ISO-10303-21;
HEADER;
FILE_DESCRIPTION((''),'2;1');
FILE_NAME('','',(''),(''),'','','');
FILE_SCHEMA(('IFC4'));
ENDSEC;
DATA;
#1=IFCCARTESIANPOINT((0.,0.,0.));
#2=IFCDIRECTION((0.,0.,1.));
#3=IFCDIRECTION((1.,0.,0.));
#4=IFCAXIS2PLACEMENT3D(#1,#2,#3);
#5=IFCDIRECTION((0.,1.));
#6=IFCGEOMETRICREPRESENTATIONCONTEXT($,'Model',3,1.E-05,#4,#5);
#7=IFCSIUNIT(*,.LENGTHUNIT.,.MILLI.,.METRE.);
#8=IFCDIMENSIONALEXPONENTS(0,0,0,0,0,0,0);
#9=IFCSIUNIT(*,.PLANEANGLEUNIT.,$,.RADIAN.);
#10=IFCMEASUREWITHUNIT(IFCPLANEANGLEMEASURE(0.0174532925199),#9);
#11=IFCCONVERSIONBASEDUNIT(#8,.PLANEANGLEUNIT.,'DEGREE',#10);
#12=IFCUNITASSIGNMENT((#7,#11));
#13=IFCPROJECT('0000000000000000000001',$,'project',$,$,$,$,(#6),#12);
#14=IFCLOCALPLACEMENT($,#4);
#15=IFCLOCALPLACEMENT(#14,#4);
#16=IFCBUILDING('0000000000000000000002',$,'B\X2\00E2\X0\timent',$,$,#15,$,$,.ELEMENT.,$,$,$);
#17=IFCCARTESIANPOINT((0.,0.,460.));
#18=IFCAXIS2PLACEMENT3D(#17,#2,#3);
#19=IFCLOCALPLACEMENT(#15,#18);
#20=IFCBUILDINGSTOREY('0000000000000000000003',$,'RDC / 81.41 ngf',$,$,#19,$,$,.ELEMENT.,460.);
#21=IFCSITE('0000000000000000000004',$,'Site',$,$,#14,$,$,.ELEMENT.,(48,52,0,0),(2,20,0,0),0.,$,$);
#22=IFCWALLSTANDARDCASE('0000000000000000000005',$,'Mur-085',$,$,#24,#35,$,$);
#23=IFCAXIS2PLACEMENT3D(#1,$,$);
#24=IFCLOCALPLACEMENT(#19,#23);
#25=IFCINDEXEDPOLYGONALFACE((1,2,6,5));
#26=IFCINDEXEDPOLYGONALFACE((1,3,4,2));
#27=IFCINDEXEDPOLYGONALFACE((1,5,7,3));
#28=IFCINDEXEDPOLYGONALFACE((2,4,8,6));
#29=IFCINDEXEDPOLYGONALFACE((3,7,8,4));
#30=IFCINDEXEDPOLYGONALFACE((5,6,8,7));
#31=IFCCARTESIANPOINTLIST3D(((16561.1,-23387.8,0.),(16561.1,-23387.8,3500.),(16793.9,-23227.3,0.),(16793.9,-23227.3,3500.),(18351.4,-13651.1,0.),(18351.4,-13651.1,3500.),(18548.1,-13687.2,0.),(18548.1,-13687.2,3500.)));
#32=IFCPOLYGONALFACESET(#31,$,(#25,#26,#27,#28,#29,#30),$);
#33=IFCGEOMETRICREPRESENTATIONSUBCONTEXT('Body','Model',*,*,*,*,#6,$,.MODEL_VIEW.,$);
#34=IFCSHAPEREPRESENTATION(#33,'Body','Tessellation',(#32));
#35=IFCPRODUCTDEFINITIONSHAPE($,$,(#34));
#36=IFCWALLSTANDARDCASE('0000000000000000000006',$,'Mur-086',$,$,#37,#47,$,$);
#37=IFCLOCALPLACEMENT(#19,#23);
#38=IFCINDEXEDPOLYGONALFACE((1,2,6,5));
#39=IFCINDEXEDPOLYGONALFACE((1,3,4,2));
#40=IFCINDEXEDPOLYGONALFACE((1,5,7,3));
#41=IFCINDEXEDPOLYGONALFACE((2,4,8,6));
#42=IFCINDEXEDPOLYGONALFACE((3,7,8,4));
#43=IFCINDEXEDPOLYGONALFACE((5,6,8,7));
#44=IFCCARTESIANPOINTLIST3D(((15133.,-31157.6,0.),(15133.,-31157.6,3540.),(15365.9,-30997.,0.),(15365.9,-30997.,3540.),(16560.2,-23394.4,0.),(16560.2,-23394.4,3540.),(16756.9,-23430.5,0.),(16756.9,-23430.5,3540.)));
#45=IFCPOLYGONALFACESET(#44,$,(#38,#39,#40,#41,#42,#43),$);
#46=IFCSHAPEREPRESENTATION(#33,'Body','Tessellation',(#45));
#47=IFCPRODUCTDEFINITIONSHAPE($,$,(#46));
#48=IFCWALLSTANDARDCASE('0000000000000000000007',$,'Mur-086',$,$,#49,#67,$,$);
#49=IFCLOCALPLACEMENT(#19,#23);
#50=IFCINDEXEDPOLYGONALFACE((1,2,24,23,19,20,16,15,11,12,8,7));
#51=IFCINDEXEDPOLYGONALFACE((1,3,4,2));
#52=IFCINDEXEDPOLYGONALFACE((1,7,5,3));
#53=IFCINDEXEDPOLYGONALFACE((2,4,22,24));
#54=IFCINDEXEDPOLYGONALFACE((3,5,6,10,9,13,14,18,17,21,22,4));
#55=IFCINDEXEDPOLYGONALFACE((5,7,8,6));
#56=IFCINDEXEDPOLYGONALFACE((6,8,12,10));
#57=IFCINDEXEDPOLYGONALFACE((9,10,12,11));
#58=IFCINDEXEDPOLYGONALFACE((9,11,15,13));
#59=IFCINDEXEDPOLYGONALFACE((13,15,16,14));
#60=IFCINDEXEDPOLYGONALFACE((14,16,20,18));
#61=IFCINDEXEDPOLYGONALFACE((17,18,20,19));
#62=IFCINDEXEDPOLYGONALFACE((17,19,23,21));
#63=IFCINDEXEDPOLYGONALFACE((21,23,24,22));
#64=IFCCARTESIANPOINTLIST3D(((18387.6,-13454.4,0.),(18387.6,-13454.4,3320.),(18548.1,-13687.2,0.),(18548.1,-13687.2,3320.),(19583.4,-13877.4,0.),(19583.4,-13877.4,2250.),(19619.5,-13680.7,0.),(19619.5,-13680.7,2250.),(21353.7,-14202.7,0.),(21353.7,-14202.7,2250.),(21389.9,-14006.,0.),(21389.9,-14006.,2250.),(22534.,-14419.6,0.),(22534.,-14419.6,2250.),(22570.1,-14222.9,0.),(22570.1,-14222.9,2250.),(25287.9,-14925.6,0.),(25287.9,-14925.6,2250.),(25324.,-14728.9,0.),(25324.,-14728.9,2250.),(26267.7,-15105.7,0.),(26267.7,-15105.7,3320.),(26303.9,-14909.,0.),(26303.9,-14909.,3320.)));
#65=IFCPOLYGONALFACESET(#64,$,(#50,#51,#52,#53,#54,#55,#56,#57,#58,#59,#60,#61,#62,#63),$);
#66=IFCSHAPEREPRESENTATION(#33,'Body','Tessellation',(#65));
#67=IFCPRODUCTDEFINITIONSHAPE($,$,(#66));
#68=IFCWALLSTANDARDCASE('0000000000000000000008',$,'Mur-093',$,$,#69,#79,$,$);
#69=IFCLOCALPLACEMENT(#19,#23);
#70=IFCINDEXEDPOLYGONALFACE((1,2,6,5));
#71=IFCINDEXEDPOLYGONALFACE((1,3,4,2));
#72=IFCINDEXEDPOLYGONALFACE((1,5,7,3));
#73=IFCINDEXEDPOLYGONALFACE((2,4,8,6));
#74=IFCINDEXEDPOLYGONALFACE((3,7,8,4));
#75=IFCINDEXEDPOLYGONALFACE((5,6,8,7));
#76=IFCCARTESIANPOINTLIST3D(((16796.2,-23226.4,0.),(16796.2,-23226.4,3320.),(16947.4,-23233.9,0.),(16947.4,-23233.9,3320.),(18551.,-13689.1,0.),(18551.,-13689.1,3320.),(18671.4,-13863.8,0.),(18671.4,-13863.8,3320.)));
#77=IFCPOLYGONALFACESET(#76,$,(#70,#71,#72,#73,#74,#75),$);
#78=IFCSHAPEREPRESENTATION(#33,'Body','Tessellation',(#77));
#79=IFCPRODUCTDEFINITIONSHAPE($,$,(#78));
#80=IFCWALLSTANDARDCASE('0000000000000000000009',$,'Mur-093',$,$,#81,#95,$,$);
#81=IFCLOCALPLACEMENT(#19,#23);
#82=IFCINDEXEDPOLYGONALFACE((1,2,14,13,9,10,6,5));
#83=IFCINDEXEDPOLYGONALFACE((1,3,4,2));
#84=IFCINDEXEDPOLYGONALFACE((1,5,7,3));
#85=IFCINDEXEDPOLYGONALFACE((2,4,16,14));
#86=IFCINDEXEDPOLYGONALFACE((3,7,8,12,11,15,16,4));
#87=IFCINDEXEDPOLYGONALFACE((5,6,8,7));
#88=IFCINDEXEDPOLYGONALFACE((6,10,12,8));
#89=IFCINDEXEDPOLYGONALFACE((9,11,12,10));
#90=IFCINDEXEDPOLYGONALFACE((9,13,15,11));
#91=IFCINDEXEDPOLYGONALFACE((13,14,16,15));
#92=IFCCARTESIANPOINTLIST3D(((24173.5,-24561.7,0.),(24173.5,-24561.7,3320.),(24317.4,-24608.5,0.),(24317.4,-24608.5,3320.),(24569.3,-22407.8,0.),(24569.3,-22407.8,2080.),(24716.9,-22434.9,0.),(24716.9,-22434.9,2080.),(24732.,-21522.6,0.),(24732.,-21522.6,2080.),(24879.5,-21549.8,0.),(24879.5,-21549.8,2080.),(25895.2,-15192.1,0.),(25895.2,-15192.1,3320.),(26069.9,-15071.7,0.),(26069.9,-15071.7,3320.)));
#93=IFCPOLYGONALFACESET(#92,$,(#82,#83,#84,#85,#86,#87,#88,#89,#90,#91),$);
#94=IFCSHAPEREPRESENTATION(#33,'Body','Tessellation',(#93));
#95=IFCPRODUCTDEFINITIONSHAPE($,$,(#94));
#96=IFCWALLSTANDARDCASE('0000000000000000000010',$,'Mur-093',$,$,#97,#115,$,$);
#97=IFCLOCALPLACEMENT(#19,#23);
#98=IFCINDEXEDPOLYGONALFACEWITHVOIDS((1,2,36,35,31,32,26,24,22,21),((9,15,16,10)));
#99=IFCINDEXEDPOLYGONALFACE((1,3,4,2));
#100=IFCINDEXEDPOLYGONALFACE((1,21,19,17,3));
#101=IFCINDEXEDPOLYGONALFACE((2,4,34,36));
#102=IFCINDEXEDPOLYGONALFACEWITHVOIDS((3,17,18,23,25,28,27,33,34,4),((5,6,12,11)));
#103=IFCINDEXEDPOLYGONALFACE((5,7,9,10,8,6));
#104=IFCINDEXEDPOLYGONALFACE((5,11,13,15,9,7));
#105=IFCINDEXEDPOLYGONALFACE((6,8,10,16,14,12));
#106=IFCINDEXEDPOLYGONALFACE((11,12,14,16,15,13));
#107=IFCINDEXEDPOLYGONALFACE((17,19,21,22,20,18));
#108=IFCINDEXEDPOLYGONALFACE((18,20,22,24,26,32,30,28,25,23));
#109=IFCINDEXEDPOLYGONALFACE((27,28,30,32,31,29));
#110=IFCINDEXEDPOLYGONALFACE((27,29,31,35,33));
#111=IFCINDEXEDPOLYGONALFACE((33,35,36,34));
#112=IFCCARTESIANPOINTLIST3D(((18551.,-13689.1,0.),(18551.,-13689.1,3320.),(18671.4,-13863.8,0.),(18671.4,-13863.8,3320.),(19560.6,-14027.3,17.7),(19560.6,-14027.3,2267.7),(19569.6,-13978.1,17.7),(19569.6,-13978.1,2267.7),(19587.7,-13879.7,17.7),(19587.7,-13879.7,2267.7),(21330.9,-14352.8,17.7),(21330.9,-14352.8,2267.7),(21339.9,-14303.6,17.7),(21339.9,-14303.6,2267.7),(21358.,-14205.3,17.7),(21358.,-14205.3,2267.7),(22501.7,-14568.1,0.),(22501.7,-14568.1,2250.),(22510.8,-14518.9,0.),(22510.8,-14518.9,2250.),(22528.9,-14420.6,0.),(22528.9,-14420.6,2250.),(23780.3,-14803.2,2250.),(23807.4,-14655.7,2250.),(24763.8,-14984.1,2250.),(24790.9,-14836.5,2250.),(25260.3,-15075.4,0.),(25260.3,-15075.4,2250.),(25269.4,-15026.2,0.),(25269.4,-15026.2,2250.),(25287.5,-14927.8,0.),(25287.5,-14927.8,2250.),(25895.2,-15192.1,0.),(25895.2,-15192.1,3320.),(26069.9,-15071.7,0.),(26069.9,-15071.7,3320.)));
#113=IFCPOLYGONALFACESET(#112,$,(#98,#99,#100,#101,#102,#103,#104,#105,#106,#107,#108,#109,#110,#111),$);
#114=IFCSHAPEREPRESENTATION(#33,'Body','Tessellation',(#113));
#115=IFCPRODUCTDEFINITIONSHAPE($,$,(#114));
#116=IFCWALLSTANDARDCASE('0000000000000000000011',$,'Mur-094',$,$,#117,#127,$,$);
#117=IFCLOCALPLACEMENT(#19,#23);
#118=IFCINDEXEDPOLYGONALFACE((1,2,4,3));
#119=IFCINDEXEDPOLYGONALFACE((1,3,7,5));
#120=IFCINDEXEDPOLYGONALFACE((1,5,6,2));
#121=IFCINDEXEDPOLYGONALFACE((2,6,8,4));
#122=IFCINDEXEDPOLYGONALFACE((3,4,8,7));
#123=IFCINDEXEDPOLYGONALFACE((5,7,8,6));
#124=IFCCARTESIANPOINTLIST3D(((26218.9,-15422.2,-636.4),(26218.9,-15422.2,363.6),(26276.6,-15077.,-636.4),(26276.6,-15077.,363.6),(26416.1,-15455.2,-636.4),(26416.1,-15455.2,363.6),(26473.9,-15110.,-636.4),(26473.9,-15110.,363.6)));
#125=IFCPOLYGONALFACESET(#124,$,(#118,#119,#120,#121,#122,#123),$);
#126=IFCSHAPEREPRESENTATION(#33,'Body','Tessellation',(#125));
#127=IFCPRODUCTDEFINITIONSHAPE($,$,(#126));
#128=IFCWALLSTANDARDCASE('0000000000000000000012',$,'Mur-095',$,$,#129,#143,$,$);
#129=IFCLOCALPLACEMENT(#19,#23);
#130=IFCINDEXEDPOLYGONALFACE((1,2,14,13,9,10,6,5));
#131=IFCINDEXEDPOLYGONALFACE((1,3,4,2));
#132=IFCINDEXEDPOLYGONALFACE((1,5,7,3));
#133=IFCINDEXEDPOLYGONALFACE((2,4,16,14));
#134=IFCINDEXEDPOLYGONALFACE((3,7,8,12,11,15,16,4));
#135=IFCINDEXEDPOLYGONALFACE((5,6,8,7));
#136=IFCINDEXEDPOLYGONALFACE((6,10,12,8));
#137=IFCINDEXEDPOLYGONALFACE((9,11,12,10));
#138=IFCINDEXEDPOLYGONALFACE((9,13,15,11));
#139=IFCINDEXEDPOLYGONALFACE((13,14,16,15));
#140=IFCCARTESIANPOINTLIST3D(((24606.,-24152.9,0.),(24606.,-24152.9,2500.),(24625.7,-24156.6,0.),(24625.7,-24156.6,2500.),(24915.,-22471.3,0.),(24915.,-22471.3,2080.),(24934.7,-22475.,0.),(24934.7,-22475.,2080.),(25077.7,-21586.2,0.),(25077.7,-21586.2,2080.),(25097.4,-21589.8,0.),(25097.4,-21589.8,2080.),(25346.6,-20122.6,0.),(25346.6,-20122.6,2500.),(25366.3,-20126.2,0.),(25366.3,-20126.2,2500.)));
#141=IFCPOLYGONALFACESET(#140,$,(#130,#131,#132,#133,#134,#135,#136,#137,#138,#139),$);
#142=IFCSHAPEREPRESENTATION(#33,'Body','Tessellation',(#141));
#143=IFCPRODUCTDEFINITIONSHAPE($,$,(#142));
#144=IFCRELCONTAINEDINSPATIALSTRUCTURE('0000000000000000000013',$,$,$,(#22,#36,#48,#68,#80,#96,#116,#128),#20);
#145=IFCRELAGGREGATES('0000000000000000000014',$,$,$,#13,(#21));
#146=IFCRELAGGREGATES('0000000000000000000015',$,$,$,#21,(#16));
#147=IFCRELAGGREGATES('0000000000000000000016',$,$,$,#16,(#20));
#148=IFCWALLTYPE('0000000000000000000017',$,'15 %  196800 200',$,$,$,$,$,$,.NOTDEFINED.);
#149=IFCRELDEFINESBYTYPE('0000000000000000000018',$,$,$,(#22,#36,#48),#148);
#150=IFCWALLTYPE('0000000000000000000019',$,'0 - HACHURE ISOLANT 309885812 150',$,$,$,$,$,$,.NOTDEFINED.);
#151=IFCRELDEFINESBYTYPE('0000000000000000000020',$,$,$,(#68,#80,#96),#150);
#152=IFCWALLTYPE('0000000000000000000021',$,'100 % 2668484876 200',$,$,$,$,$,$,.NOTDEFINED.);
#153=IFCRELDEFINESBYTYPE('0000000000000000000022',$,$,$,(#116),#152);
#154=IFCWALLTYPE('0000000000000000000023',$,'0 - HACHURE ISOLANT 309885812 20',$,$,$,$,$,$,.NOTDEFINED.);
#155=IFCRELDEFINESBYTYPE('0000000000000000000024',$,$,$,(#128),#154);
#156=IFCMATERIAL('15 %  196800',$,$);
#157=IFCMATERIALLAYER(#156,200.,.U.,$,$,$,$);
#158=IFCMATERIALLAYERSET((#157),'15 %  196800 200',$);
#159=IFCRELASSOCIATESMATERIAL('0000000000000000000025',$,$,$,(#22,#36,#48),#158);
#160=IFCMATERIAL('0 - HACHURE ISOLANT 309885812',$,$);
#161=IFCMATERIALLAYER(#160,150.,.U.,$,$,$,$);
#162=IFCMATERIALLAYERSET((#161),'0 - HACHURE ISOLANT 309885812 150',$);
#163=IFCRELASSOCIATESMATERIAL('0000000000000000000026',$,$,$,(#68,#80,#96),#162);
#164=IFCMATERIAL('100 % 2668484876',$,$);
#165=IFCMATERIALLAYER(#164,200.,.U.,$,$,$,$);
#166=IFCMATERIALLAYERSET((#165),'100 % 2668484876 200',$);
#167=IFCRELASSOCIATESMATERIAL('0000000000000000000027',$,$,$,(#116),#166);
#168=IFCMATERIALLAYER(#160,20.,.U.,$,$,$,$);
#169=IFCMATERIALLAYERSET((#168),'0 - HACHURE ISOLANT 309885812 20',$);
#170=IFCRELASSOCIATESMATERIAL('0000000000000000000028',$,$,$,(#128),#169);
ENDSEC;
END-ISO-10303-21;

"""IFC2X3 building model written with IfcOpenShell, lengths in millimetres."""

from ifc_helpers import new_model, entity, si_unit, converted_unit, direction, frame, origin_with_axes, origin_2d_with_axis, place, context, subcontext, project, spatial, polyline, rectangle, outline, extrude, material, layer, layer_set, layer_usage, type_object, element, save


model = new_model("IFC2X3")

# Units and contexts
model_context = context("Model", 3, precision=1e-05, world=origin_with_axes(), true_north=direction((0.0, 1.0)))
body_context = subcontext(model_context, "Body", "Model", "MODEL_VIEW")
ifc_project = project(units=[si_unit("LENGTHUNIT", "METRE", prefix="MILLI"), converted_unit("PLANEANGLEUNIT", "DEGREE", entity("IfcPlaneAngleMeasure", 0.0174532925199), si_unit("PLANEANGLEUNIT", "RADIAN"), dimensions=[0, 0, 0, 0, 0, 0, 0])], contexts=[model_context])

# Site, building, storey
site_placement = place(None, origin_with_axes())
site = spatial("IfcSite", under=ifc_project, at=site_placement, Name="Site", CompositionType="ELEMENT", RefLatitude=(48, 52, 0, 0), RefLongitude=(2, 20, 0, 0), RefElevation=0.0)
building_placement = place(site_placement, origin_with_axes())
building = spatial("IfcBuilding", under=site, at=building_placement, Name="Bâtiment", CompositionType="ELEMENT")
storey_placement = place(building_placement, frame((0.0, 0.0, 460.0), z_axis=(0.0, 0.0, 1.0), x_axis=(1.0, 0.0, 0.0)))
storey = spatial("IfcBuildingStorey", under=building, at=storey_placement, Name="RDC / 81.41 ngf", CompositionType="ELEMENT", Elevation=460.0)

# Shared definitions
ifc_material_1 = material(Name="100 % 2668484876")
ifc_material_2 = material(Name="15 %  196800")

# Shared definitions
ifc_layer_1 = layer(ifc_material_2, 200.0, ventilated="UNKNOWN")
ifc_layer_set_1 = layer_set([ifc_layer_1], Name="15 %  196800 200")
wall_type_1 = type_object("IfcWallType", Name="15 %  196800 200", PredefinedType="NOTDEFINED")

# Walls
ifc_layer_usage_1 = layer_usage(ifc_layer_set_1, "AXIS2", "NEGATIVE", 0.0)
wall_1_placement = place(storey_placement, frame((16597.2, -23191.1, 0.0), z_axis=(0.0, 0.0, 1.0), x_axis=(0.180844, 0.983512, 0.0)))
element("IfcWallStandardCase", 1, at=wall_1_placement, inside=storey, type_object=wall_type_1, material=ifc_layer_usage_1, Name="Mur-085", context=body_context, shape_type="SweptSolid", body=[
    extrude(outline(polyline([(0.0, -200.0), (9700.0, -200.0), (9700.0, 0.0), (-200.0, 0.0), (0.0, -200.0)])), origin_with_axes(), (0.0, 0.0, 1.0), 3500.0),
])
ifc_layer_usage_2 = layer_usage(ifc_layer_set_1, "AXIS2", "POSITIVE", 0.0)
wall_2_placement = place(storey_placement, frame((16560.2, -23394.4, 0.0), z_axis=(0.0, 0.0, 1.0), x_axis=(-0.180809, -0.983518, 0.0)))
element("IfcWallStandardCase", 2, at=wall_2_placement, inside=storey, type_object=wall_type_1, material=ifc_layer_usage_2, Name="Mur-086", context=body_context, shape_type="SweptSolid", body=[
    extrude(outline(polyline([(0.0, 0.0), (7893.3, 0.0), (7693.3, 200.0), (0.0, 200.0), (0.0, 0.0)])), origin_with_axes(), (0.0, 0.0, 1.0), 3540.0),
])

# Wall, openings
ifc_layer_usage_3 = layer_usage(ifc_layer_set_1, "AXIS2", "POSITIVE", -200.0)
wall_3_placement = place(storey_placement, frame((18387.6, -13454.4, 0.0), z_axis=(0.0, 0.0, 1.0), x_axis=(0.983534, -0.180723, 0.0)))
wall_3 = element("IfcWallStandardCase", 3, at=wall_3_placement, inside=storey, type_object=wall_type_1, material=ifc_layer_usage_3, Name="Mur-086", context=body_context, shape_type="SweptSolid", body=[
    extrude(outline(polyline([(200.0, -200.0), (8048.8, -200.0), (8048.8, 0.0), (0.0, 0.0), (200.0, -200.0)])), origin_with_axes(), (0.0, 0.0, 1.0), 3320.0),
])
opening_1_placement = place(wall_3_placement, frame((2152.6, 0.0, 0.0), z_axis=(0.0, 0.0, 1.0), x_axis=(1.0, 0.0, 0.0)))
element("IfcOpeningElement", 4, at=opening_1_placement, cuts=wall_3, context=body_context, shape_type="SweptSolid", body=[
    extrude(rectangle(XDim=1800.0, YDim=2250.0, at=origin_2d_with_axis()), frame((0.0, 200.0, 1125.0), z_axis=(0.0, -1.0, 0.0), x_axis=(1.0, 0.0, 0.0)), (0.0, 0.0, 1.0), 600.0),
])
opening_2_placement = place(wall_3_placement, frame((5652.6, 0.0, 0.0), z_axis=(0.0, 0.0, 1.0), x_axis=(1.0, 0.0, 0.0)))
element("IfcOpeningElement", 5, at=opening_2_placement, cuts=wall_3, context=body_context, shape_type="SweptSolid", body=[
    extrude(rectangle(XDim=2800.0, YDim=2250.0, at=origin_2d_with_axis()), frame((0.0, 200.0, 1125.0), z_axis=(0.0, -1.0, 0.0), x_axis=(1.0, 0.0, 0.0)), (0.0, 0.0, 1.0), 600.0),
])

# Wall
ifc_material_3 = material(Name="0 - HACHURE ISOLANT 309885812")
ifc_layer_2 = layer(ifc_material_3, 150.0, ventilated="UNKNOWN")
ifc_layer_set_2 = layer_set([ifc_layer_2], Name="0 - HACHURE ISOLANT 309885812 150")
ifc_layer_usage_4 = layer_usage(ifc_layer_set_2, "AXIS2", "POSITIVE", -150.0)
wall_type_2 = type_object("IfcWallType", Name="0 - HACHURE ISOLANT 309885812 150", PredefinedType="NOTDEFINED")
wall_4_placement = place(storey_placement, frame((18671.4, -13863.8, 0.0), z_axis=(0.0, 0.0, 1.0), x_axis=(-0.180951, -0.983492, 0.0)))
element("IfcWallStandardCase", 6, at=wall_4_placement, inside=storey, type_object=wall_type_2, material=ifc_layer_usage_4, Name="Mur-093", context=body_context, shape_type="SweptSolid", body=[
    extrude(outline(polyline([(-150.0, -150.0), (9547.4, -150.0), (9527.4, 0.0), (0.0, 0.0), (-150.0, -150.0)])), origin_with_axes(), (0.0, 0.0, 1.0), 3320.0),
])

# Wall, opening
ifc_layer_usage_5 = layer_usage(ifc_layer_set_2, "AXIS2", "NEGATIVE", 150.0)
wall_5_placement = place(storey_placement, frame((25895.2, -15192.1, 0.0), z_axis=(0.0, 0.0, 1.0), x_axis=(-0.180728, -0.983533, 0.0)))
wall_5 = element("IfcWallStandardCase", 7, at=wall_5_placement, inside=storey, type_object=wall_type_2, material=ifc_layer_usage_5, Name="Mur-093", context=body_context, shape_type="SweptSolid", body=[
    extrude(outline(polyline([(0.0, 0.0), (9526.5, 0.0), (9546.5, 150.0), (-150.0, 150.0), (0.0, 0.0)])), origin_with_axes(), (0.0, 0.0, 1.0), 3320.0),
])
opening_3_placement = place(wall_5_placement, frame((6886.5, 0.0, 0.0), z_axis=(0.0, 0.0, 1.0), x_axis=(1.0, 0.0, 0.0)))
element("IfcOpeningElement", 8, at=opening_3_placement, cuts=wall_5, context=body_context, shape_type="SweptSolid", body=[
    extrude(rectangle(XDim=900.0, YDim=2080.0, at=origin_2d_with_axis()), frame((0.0, 300.0, 1040.0), z_axis=(0.0, -1.0, 0.0), x_axis=(1.0, 0.0, 0.0)), (0.0, 0.0, 1.0), 450.0),
])

# Wall, openings
ifc_layer_usage_6 = layer_usage(ifc_layer_set_2, "AXIS2", "POSITIVE", -150.0)
wall_6_placement = place(storey_placement, frame((25895.2, -15192.1, 0.0), z_axis=(0.0, 0.0, 1.0), x_axis=(-0.98351, 0.180854, 0.0)))
wall_6 = element("IfcWallStandardCase", 9, at=wall_6_placement, inside=storey, type_object=wall_type_2, material=ifc_layer_usage_6, Name="Mur-093", context=body_context, shape_type="SweptSolid", body=[
    extrude(outline(polyline([(-150.0, -150.0), (7495.0, -150.0), (7345.0, 0.0), (0.0, 0.0), (-150.0, -150.0)])), origin_with_axes(), (0.0, 0.0, 1.0), 3320.0),
])
opening_4_placement = place(wall_6_placement, frame((2800.4, 0.0, 0.0), z_axis=(0.0, 0.0, 1.0), x_axis=(1.0, 0.0, 0.0)))
element("IfcOpeningElement", 10, at=opening_4_placement, cuts=wall_6, context=body_context, shape_type="SweptSolid", body=[
    extrude(rectangle(XDim=1300.0, YDim=2250.0, at=origin_2d_with_axis()), frame((0.0, -300.0, 1125.0), z_axis=(0.0, -1.0, 0.0), x_axis=(1.0, 0.0, 0.0)), (0.0, 0.0, -1.0), 250.0),
    extrude(rectangle(XDim=1300.0, YDim=2250.0, at=origin_2d_with_axis()), frame((0.0, 150.0, 1125.0), z_axis=(0.0, 1.0, 0.0), x_axis=(1.0, 0.0, 0.0)), (0.0, 0.0, -1.0), 200.0),
])
opening_5_placement = place(wall_6_placement, frame((5540.9, 0.0, 17.7), z_axis=(0.0, 0.0, 1.0), x_axis=(1.0, 0.0, 0.0)))
element("IfcOpeningElement", 11, at=opening_5_placement, cuts=wall_6, context=body_context, shape_type="SweptSolid", body=[
    extrude(rectangle(XDim=1800.0, YDim=2250.0, at=origin_2d_with_axis()), frame((0.0, -300.0, 1125.0), z_axis=(0.0, 1.0, 0.0), x_axis=(1.0, 0.0, 0.0)), (0.0, 0.0, 1.0), 250.0),
    extrude(rectangle(XDim=1800.0, YDim=2250.0, at=origin_2d_with_axis()), frame((0.0, 150.0, 1125.0), z_axis=(0.0, -1.0, 0.0), x_axis=(1.0, 0.0, 0.0)), (0.0, 0.0, 1.0), 200.0),
])
opening_6_placement = place(wall_6_placement, frame((1650.4, 0.0, 0.0), z_axis=(0.0, 0.0, 1.0), x_axis=(1.0, 0.0, 0.0)))
element("IfcOpeningElement", 12, at=opening_6_placement, cuts=wall_6, context=body_context, shape_type="SweptSolid", body=[
    extrude(rectangle(XDim=1000.0, YDim=2250.0, at=origin_2d_with_axis()), frame((0.0, -300.0, 1125.0), z_axis=(0.0, -1.0, 0.0), x_axis=(1.0, 0.0, 0.0)), (0.0, 0.0, -1.0), 250.0),
    extrude(rectangle(XDim=1000.0, YDim=2250.0, at=origin_2d_with_axis()), frame((0.0, 150.0, 1125.0), z_axis=(0.0, 1.0, 0.0), x_axis=(1.0, 0.0, 0.0)), (0.0, 0.0, -1.0), 200.0),
])
opening_7_placement = place(wall_6_placement, frame((898.0, 0.0, 0.0), z_axis=(0.0, 0.0, 1.0), x_axis=(1.0, 0.0, 0.0)))
element("IfcOpeningElement", 13, at=opening_7_placement, cuts=wall_6, context=body_context, shape_type="SweptSolid", body=[
    extrude(rectangle(XDim=504.8, YDim=2250.0, at=origin_2d_with_axis()), frame((0.0, -300.0, 1125.0), z_axis=(0.0, -1.0, 0.0), x_axis=(1.0, 0.0, 0.0)), (0.0, 0.0, -1.0), 250.0),
    extrude(rectangle(XDim=504.8, YDim=2250.0, at=origin_2d_with_axis()), frame((0.0, 150.0, 1125.0), z_axis=(0.0, 1.0, 0.0), x_axis=(1.0, 0.0, 0.0)), (0.0, 0.0, -1.0), 200.0),
])

# Wall
ifc_layer_3 = layer(ifc_material_1, 200.0, ventilated="UNKNOWN")
ifc_layer_set_3 = layer_set([ifc_layer_3], Name="100 % 2668484876 200")
ifc_layer_usage_7 = layer_usage(ifc_layer_set_3, "AXIS2", "NEGATIVE", 200.0)
wall_type_3 = type_object("IfcWallType", Name="100 % 2668484876 200", PredefinedType="NOTDEFINED")
wall_7_placement = place(storey_placement, frame((26276.6, -15077.0, -636.4), z_axis=(0.0, 0.0, 1.0), x_axis=(-0.165016, -0.986291, 0.0)))
element("IfcWallStandardCase", 14, at=wall_7_placement, inside=storey, type_object=wall_type_3, material=ifc_layer_usage_7, Name="Mur-094", context=body_context, shape_type="SweptSolid", body=[
    extrude(outline(polyline([(0.0, 0.0), (350.0, 0.0), (350.0, 200.0), (0.0, 200.0), (0.0, 0.0)])), origin_with_axes(), (0.0, 0.0, 1.0), 1000.0),
])

# Shared definitions
ifc_layer_4 = layer(ifc_material_3, 20.0, ventilated="UNKNOWN")
ifc_layer_set_4 = layer_set([ifc_layer_4], Name="0 - HACHURE ISOLANT 309885812 20")
wall_type_4 = type_object("IfcWallType", Name="0 - HACHURE ISOLANT 309885812 20", PredefinedType="NOTDEFINED")

# Wall, opening
ifc_layer_usage_8 = layer_usage(ifc_layer_set_4, "AXIS2", "POSITIVE", -20.0)
wall_8_placement = place(storey_placement, frame((25366.3, -20126.2, 0.0), z_axis=(0.0, 0.0, 1.0), x_axis=(-0.180728, -0.983533, 0.0)))
wall_8 = element("IfcWallStandardCase", 15, at=wall_8_placement, inside=storey, type_object=wall_type_4, material=ifc_layer_usage_8, Name="Mur-095", context=body_context, shape_type="SweptSolid", body=[
    extrude(outline(polyline([(0.0, -20.0), (4097.9, -20.0), (4097.9, 0.0), (0.0, 0.0), (0.0, -20.0)])), origin_with_axes(), (0.0, 0.0, 1.0), 2500.0),
])
opening_8_placement = place(wall_8_placement, frame((1938.1, 0.0, 0.0), z_axis=(0.0, 0.0, 1.0), x_axis=(1.0, 0.0, 0.0)))
element("IfcOpeningElement", 16, at=opening_8_placement, cuts=wall_8, context=body_context, shape_type="SweptSolid", body=[
    extrude(rectangle(XDim=900.0, YDim=2080.0, at=origin_2d_with_axis()), frame((0.0, -40.0, 1040.0), z_axis=(0.0, -1.0, 0.0), x_axis=(1.0, 0.0, 0.0)), (0.0, 0.0, -1.0), 60.0),
])

save(model, "model.ifc")
